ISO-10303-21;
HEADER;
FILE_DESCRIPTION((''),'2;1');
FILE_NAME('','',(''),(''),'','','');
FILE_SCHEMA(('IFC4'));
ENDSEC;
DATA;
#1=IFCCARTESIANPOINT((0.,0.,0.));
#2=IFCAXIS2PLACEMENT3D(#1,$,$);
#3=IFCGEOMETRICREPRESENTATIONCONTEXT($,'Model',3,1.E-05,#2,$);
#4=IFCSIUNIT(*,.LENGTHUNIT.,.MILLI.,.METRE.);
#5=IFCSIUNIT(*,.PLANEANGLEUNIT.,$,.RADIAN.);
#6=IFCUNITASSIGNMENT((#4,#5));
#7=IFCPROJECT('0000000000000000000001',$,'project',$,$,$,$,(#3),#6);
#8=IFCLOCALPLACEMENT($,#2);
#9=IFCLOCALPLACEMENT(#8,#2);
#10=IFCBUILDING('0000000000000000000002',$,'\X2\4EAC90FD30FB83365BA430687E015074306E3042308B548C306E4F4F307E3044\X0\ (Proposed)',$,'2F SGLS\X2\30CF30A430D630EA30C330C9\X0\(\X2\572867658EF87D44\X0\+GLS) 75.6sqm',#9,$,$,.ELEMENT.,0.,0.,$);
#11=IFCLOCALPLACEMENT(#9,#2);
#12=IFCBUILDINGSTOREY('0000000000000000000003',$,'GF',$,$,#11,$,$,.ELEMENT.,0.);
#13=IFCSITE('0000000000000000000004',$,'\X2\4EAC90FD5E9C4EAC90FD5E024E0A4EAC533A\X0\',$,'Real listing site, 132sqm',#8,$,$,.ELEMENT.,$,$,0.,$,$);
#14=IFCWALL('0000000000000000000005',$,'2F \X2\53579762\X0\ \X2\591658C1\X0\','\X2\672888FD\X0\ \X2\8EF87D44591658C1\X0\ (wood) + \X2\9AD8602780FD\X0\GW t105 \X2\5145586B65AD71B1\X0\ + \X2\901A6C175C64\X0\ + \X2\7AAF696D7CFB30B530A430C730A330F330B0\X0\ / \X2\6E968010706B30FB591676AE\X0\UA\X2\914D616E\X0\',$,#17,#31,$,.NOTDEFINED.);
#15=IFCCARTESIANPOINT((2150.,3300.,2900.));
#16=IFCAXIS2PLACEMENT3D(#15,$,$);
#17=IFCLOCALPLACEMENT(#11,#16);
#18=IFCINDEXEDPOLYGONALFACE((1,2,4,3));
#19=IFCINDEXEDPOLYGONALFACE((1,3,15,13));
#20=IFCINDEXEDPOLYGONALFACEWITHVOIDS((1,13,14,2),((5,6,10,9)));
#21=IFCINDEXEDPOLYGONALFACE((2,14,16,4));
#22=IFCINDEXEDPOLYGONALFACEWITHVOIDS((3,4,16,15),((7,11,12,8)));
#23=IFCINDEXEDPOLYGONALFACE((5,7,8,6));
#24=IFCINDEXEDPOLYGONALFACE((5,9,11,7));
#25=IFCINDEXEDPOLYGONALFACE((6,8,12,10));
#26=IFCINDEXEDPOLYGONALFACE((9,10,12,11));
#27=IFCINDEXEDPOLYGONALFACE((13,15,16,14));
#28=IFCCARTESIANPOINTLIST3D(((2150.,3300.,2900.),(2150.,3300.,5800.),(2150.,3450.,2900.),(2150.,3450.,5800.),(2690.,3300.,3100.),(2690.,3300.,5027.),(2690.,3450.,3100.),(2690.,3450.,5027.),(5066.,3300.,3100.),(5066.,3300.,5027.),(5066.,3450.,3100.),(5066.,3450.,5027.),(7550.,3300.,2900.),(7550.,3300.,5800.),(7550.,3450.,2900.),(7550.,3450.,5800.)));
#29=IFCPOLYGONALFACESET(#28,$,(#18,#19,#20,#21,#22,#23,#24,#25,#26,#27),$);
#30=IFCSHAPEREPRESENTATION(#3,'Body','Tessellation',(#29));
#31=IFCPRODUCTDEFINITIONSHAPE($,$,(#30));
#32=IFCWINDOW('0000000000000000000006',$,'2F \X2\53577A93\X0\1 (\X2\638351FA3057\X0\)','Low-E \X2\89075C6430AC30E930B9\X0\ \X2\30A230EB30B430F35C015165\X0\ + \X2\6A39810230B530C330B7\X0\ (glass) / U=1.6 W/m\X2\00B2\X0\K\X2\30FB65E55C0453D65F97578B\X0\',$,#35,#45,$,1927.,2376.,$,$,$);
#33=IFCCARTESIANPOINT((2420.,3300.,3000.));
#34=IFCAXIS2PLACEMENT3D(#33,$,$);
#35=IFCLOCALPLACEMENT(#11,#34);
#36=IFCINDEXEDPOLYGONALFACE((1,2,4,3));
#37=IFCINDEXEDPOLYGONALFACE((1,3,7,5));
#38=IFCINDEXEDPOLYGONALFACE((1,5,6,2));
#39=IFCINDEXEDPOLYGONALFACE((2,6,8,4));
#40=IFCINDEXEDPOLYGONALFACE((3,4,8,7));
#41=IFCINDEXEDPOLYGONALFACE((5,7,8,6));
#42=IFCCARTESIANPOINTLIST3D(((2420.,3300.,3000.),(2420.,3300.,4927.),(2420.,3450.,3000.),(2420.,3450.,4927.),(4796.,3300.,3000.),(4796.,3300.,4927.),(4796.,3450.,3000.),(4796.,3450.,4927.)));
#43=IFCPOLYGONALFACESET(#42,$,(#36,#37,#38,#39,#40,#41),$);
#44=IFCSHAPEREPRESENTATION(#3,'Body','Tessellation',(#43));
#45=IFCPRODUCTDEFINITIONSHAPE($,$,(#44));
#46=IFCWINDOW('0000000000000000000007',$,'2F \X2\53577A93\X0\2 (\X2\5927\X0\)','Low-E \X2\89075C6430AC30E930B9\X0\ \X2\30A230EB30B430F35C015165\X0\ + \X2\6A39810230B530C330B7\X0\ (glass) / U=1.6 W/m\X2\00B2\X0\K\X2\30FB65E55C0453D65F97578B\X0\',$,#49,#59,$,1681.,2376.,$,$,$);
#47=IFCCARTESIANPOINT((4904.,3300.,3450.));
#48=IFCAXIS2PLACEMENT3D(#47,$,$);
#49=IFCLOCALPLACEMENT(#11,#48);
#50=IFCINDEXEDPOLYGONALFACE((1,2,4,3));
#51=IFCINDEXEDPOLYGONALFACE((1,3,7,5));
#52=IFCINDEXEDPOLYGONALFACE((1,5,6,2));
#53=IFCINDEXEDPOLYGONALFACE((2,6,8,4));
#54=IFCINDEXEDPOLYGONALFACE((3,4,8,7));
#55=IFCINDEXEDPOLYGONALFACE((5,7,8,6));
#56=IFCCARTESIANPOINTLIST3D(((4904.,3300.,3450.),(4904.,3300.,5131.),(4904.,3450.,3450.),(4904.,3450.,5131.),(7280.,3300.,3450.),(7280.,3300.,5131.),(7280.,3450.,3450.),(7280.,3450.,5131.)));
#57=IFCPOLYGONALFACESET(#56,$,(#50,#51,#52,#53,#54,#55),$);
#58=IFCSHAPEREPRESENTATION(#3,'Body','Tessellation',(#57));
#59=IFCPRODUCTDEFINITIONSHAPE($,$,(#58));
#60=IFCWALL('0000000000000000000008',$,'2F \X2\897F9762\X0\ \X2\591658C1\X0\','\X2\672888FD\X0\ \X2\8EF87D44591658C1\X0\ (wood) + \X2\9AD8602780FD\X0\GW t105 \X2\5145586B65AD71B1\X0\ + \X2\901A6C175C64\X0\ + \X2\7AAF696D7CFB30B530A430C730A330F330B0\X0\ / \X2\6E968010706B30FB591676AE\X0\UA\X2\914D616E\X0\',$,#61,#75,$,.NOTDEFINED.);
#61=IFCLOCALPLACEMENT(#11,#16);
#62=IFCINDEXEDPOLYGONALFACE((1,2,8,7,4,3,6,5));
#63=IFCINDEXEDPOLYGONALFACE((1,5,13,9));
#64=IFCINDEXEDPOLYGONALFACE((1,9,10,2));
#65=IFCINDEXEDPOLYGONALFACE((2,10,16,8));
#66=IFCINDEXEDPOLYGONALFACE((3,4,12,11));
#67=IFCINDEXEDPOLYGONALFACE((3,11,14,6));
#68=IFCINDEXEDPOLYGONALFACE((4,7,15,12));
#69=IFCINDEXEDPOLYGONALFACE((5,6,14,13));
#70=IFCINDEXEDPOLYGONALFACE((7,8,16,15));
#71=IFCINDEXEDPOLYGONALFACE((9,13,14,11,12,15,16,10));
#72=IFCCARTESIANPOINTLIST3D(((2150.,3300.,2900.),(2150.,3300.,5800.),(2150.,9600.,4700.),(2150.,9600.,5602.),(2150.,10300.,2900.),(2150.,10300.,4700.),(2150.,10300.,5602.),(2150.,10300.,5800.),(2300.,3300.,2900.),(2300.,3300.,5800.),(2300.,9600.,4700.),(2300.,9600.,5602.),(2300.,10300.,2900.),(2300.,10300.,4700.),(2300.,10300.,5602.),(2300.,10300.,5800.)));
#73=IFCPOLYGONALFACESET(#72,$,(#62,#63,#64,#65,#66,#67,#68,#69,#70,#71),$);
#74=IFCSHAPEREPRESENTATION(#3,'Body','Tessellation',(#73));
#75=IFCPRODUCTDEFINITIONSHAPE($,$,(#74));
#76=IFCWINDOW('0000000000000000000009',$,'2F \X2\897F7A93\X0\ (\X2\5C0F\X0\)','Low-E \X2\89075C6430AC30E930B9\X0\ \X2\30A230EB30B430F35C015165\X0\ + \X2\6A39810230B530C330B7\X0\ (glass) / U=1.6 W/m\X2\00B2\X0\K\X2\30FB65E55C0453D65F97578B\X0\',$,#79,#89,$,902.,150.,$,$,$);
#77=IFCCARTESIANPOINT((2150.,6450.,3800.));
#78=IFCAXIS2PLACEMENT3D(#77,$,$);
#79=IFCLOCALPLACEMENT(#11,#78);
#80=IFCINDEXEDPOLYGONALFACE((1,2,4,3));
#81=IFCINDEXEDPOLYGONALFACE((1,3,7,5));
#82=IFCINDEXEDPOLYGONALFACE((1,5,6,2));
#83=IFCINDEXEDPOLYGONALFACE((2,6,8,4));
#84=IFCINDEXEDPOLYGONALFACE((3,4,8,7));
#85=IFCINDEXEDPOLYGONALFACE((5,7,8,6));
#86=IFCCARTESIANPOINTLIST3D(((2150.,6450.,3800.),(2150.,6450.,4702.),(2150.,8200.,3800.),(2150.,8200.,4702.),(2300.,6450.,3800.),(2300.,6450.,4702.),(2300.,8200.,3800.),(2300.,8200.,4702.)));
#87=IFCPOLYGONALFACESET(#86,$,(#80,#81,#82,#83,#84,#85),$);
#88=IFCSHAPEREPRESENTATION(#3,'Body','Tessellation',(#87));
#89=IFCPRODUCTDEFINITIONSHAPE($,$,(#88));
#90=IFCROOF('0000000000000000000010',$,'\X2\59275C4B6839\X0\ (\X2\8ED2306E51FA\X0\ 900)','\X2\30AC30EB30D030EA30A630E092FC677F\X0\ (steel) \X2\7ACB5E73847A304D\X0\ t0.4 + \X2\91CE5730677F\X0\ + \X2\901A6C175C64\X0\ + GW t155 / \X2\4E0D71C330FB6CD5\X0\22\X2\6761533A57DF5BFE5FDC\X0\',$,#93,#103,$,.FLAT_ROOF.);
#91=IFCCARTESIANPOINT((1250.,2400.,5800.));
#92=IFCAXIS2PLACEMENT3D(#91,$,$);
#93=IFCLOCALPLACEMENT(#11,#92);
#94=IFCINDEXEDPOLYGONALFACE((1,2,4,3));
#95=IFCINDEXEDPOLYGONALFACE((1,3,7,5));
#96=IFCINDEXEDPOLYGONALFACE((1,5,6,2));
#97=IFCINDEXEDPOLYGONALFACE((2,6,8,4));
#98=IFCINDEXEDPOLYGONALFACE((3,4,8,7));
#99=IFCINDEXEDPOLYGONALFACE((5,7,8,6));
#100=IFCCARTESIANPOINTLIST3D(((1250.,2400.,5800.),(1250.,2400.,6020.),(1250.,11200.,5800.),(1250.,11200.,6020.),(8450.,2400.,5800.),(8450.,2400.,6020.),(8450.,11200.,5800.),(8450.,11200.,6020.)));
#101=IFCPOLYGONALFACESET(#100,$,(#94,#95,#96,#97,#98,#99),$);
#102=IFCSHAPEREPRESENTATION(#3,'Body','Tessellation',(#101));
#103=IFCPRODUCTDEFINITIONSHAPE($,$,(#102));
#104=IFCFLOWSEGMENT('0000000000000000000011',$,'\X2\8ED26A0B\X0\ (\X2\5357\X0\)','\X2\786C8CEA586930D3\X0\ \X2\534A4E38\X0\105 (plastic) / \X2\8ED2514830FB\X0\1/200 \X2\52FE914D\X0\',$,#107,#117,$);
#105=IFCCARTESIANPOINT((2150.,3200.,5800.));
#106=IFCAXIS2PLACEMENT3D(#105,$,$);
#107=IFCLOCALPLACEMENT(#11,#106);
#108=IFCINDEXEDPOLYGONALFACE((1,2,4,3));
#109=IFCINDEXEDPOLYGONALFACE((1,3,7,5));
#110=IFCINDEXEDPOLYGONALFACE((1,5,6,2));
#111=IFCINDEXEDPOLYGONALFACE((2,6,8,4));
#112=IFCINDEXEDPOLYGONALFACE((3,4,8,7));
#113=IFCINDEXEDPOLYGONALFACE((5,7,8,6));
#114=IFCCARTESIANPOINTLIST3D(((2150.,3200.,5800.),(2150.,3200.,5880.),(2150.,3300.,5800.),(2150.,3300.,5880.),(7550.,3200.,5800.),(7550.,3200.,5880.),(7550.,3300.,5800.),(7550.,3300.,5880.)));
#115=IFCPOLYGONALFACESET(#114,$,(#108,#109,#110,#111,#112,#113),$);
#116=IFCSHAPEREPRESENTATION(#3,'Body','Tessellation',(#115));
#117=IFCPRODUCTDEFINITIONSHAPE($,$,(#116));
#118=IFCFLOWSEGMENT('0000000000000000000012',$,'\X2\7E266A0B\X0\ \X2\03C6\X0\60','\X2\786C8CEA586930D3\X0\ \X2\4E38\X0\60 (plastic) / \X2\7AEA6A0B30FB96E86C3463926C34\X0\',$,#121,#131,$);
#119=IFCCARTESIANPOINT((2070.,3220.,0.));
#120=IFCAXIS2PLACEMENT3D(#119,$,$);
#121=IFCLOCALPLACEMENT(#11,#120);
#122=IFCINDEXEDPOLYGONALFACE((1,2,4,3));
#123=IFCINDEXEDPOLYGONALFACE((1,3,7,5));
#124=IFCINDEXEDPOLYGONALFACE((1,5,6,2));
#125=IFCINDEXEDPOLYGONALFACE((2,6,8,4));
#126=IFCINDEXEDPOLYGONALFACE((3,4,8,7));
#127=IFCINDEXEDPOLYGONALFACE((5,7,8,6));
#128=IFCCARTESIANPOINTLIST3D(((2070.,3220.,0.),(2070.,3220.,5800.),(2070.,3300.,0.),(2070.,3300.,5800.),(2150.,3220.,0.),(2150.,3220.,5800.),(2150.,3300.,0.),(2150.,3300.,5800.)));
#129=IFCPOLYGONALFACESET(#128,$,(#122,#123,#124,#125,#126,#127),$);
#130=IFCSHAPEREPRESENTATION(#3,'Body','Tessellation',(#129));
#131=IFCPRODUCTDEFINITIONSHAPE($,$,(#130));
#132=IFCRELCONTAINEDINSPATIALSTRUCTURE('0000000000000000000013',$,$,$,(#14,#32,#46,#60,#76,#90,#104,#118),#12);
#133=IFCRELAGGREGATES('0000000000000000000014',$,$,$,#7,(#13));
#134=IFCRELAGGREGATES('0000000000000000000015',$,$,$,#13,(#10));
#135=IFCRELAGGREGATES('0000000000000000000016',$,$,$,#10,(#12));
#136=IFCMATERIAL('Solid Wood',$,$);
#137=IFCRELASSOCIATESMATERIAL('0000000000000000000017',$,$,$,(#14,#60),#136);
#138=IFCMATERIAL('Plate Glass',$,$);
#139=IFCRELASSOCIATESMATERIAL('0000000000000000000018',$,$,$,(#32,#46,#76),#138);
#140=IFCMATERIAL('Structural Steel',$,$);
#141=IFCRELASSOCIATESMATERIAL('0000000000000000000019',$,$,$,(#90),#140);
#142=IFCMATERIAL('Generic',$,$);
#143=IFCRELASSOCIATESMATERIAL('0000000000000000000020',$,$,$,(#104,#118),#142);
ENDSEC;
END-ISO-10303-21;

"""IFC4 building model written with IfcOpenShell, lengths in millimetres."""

from ifc_helpers import new_model, si_unit, frame, frame_2d, origin, place, context, project, spatial, rectangle, extrude, material, element, fill, save


model = new_model("IFC4")

# Units and contexts
model_context = context("Model", 3, precision=1e-05, world=origin())
ifc_project = project(units=[si_unit("LENGTHUNIT", "METRE", prefix="MILLI"), si_unit("PLANEANGLEUNIT", "RADIAN")], contexts=[model_context])

# Site, building, storey
site_placement = place(None, origin())
site = spatial("IfcSite", under=ifc_project, at=site_placement, Name="京都府京都市上京区", ObjectType="Real listing site, 132sqm", CompositionType="ELEMENT", RefElevation=0.0)
building_placement = place(site_placement, origin())
building = spatial("IfcBuilding", under=site, at=building_placement, Name="京都・茶室と縁側のある和の住まい (Proposed)", ObjectType="2F SGLSハイブリッド(在来軸組+GLS) 75.6sqm", CompositionType="ELEMENT", ElevationOfRefHeight=0.0, ElevationOfTerrain=0.0)
storey_placement = place(building_placement, origin())
storey = spatial("IfcBuildingStorey", under=building, at=storey_placement, Name="GF", CompositionType="ELEMENT", Elevation=0.0)

# Shared definitions
ifc_material_1 = material(Name="Solid Wood")

# Shared definitions
ifc_material_2 = material(Name="Plate Glass")

# Wall, openings, windows
wall_1_placement = place(storey_placement, frame((2150.0, 3300.0, 2900.0)))
wall_1 = element("IfcWall", 1, at=wall_1_placement, inside=storey, material=ifc_material_1, Name="2F 南面 外壁", Description="木製 軸組外壁 (wood) + 高性能GW t105 充填断熱 + 通気層 + 窯業系サイディング / 準耐火・外皮UA配慮", PredefinedType="NOTDEFINED", context=model_context, shape_type="SweptSolid", body=[
    extrude(rectangle(XDim=5400.0, YDim=150.0, at=frame_2d((2700.0, 75.0))), frame((2150.0, 3300.0, 2900.0)), (0.0, 0.0, 1.0), 2900.0),
])
opening_1_placement = place(storey_placement, frame((2420.0, 3300.0, 3000.0)))
opening_1 = element("IfcOpeningElement", 2, at=opening_1_placement, cuts=wall_1, PredefinedType="NOTDEFINED", context=model_context, shape_type="SweptSolid", body=[
    extrude(rectangle(XDim=2376.0, YDim=150.0, at=frame_2d((1188.0, 75.0))), frame((2420.0, 3300.0, 3000.0)), (0.0, 0.0, 1.0), 1927.0),
])
opening_2_placement = place(storey_placement, frame((4904.0, 3300.0, 3450.0)))
opening_2 = element("IfcOpeningElement", 3, at=opening_2_placement, cuts=wall_1, PredefinedType="NOTDEFINED", context=model_context, shape_type="SweptSolid", body=[
    extrude(rectangle(XDim=2376.0, YDim=150.0, at=frame_2d((1188.0, 75.0))), frame((4904.0, 3300.0, 3450.0)), (0.0, 0.0, 1.0), 1681.0),
])
window_1_placement = place(storey_placement, frame((2420.0, 3300.0, 3000.0)))
window_1 = element("IfcWindow", 4, at=window_1_placement, inside=storey, material=ifc_material_2, Name="2F 南窓1 (掃出し)", Description="Low-E 複層ガラス アルゴン封入 + 樹脂サッシ (glass) / U=1.6 W/m²K・日射取得型", OverallHeight=1927.0, OverallWidth=2376.0, context=model_context, shape_type="SweptSolid", body=[
    extrude(rectangle(XDim=2376.0, YDim=150.0, at=frame_2d((1188.0, 75.0))), frame((2420.0, 3300.0, 3000.0)), (0.0, 0.0, 1.0), 1927.0),
])
fill(opening_1, window_1)
window_2_placement = place(storey_placement, frame((4904.0, 3300.0, 3450.0)))
window_2 = element("IfcWindow", 5, at=window_2_placement, inside=storey, material=ifc_material_2, Name="2F 南窓2 (大)", Description="Low-E 複層ガラス アルゴン封入 + 樹脂サッシ (glass) / U=1.6 W/m²K・日射取得型", OverallHeight=1681.0, OverallWidth=2376.0, context=model_context, shape_type="SweptSolid", body=[
    extrude(rectangle(XDim=2376.0, YDim=150.0, at=frame_2d((1188.0, 75.0))), frame((4904.0, 3300.0, 3450.0)), (0.0, 0.0, 1.0), 1681.0),
])
fill(opening_2, window_2)

# Wall, opening, window
wall_2_placement = place(storey_placement, frame((2150.0, 3300.0, 2900.0)))
wall_2 = element("IfcWall", 6, at=wall_2_placement, inside=storey, material=ifc_material_1, Name="2F 西面 外壁", Description="木製 軸組外壁 (wood) + 高性能GW t105 充填断熱 + 通気層 + 窯業系サイディング / 準耐火・外皮UA配慮", PredefinedType="NOTDEFINED", context=model_context, shape_type="SweptSolid", body=[
    extrude(rectangle(XDim=150.0, YDim=7000.0, at=frame_2d((75.0, 3500.0))), frame((2150.0, 3300.0, 2900.0)), (0.0, 0.0, 1.0), 2900.0),
])
opening_3_placement = place(storey_placement, frame((2150.0, 6450.0, 3800.0)))
opening_3 = element("IfcOpeningElement", 7, at=opening_3_placement, cuts=wall_2, PredefinedType="NOTDEFINED", context=model_context, shape_type="SweptSolid", body=[
    extrude(rectangle(XDim=150.0, YDim=1750.0, at=frame_2d((75.0, 875.0))), frame((2150.0, 6450.0, 3800.0)), (0.0, 0.0, 1.0), 902.0),
])
window_3_placement = place(storey_placement, frame((2150.0, 6450.0, 3800.0)))
window_3 = element("IfcWindow", 8, at=window_3_placement, inside=storey, material=ifc_material_2, Name="2F 西窓 (小)", Description="Low-E 複層ガラス アルゴン封入 + 樹脂サッシ (glass) / U=1.6 W/m²K・日射取得型", OverallHeight=902.0, OverallWidth=150.0, context=model_context, shape_type="SweptSolid", body=[
    extrude(rectangle(XDim=150.0, YDim=1750.0, at=frame_2d((75.0, 875.0))), frame((2150.0, 6450.0, 3800.0)), (0.0, 0.0, 1.0), 902.0),
])
fill(opening_3, window_3)

# Roof
ifc_material_3 = material(Name="Structural Steel")
roof_placement = place(storey_placement, frame((1250.0, 2400.0, 5800.0)))
element("IfcRoof", 9, at=roof_placement, inside=storey, material=ifc_material_3, Name="大屋根 (軒の出 900)", Description="ガルバリウム鋼板 (steel) 立平葺き t0.4 + 野地板 + 通気層 + GW t155 / 不燃・法22条区域対応", PredefinedType="FLAT_ROOF", context=model_context, shape_type="SweptSolid", body=[
    extrude(rectangle(XDim=7200.0, YDim=8800.0, at=frame_2d((3600.0, 4400.0))), frame((1250.0, 2400.0, 5800.0)), (0.0, 0.0, 1.0), 220.0),
])

# Flow segments
ifc_material_4 = material(Name="Generic")
flow_segment_1_placement = place(storey_placement, frame((2150.0, 3200.0, 5800.0)))
element("IfcFlowSegment", 10, at=flow_segment_1_placement, inside=storey, material=ifc_material_4, Name="軒樋 (南)", Description="硬質塩ビ 半丸105 (plastic) / 軒先・1/200 勾配", context=model_context, shape_type="SweptSolid", body=[
    extrude(rectangle(XDim=5400.0, YDim=100.0, at=frame_2d((2700.0, 50.0))), frame((2150.0, 3200.0, 5800.0)), (0.0, 0.0, 1.0), 80.0),
])
flow_segment_2_placement = place(storey_placement, frame((2070.0, 3220.0, 0.0)))
element("IfcFlowSegment", 11, at=flow_segment_2_placement, inside=storey, material=ifc_material_4, Name="縦樋 φ60", Description="硬質塩ビ 丸60 (plastic) / 竪樋・雨水排水", context=model_context, shape_type="SweptSolid", body=[
    extrude(rectangle(XDim=80.0, YDim=80.0, at=frame_2d((40.0, 40.0))), frame((2070.0, 3220.0, 0.0)), (0.0, 0.0, 1.0), 5800.0),
])

save(model, "model.ifc")
